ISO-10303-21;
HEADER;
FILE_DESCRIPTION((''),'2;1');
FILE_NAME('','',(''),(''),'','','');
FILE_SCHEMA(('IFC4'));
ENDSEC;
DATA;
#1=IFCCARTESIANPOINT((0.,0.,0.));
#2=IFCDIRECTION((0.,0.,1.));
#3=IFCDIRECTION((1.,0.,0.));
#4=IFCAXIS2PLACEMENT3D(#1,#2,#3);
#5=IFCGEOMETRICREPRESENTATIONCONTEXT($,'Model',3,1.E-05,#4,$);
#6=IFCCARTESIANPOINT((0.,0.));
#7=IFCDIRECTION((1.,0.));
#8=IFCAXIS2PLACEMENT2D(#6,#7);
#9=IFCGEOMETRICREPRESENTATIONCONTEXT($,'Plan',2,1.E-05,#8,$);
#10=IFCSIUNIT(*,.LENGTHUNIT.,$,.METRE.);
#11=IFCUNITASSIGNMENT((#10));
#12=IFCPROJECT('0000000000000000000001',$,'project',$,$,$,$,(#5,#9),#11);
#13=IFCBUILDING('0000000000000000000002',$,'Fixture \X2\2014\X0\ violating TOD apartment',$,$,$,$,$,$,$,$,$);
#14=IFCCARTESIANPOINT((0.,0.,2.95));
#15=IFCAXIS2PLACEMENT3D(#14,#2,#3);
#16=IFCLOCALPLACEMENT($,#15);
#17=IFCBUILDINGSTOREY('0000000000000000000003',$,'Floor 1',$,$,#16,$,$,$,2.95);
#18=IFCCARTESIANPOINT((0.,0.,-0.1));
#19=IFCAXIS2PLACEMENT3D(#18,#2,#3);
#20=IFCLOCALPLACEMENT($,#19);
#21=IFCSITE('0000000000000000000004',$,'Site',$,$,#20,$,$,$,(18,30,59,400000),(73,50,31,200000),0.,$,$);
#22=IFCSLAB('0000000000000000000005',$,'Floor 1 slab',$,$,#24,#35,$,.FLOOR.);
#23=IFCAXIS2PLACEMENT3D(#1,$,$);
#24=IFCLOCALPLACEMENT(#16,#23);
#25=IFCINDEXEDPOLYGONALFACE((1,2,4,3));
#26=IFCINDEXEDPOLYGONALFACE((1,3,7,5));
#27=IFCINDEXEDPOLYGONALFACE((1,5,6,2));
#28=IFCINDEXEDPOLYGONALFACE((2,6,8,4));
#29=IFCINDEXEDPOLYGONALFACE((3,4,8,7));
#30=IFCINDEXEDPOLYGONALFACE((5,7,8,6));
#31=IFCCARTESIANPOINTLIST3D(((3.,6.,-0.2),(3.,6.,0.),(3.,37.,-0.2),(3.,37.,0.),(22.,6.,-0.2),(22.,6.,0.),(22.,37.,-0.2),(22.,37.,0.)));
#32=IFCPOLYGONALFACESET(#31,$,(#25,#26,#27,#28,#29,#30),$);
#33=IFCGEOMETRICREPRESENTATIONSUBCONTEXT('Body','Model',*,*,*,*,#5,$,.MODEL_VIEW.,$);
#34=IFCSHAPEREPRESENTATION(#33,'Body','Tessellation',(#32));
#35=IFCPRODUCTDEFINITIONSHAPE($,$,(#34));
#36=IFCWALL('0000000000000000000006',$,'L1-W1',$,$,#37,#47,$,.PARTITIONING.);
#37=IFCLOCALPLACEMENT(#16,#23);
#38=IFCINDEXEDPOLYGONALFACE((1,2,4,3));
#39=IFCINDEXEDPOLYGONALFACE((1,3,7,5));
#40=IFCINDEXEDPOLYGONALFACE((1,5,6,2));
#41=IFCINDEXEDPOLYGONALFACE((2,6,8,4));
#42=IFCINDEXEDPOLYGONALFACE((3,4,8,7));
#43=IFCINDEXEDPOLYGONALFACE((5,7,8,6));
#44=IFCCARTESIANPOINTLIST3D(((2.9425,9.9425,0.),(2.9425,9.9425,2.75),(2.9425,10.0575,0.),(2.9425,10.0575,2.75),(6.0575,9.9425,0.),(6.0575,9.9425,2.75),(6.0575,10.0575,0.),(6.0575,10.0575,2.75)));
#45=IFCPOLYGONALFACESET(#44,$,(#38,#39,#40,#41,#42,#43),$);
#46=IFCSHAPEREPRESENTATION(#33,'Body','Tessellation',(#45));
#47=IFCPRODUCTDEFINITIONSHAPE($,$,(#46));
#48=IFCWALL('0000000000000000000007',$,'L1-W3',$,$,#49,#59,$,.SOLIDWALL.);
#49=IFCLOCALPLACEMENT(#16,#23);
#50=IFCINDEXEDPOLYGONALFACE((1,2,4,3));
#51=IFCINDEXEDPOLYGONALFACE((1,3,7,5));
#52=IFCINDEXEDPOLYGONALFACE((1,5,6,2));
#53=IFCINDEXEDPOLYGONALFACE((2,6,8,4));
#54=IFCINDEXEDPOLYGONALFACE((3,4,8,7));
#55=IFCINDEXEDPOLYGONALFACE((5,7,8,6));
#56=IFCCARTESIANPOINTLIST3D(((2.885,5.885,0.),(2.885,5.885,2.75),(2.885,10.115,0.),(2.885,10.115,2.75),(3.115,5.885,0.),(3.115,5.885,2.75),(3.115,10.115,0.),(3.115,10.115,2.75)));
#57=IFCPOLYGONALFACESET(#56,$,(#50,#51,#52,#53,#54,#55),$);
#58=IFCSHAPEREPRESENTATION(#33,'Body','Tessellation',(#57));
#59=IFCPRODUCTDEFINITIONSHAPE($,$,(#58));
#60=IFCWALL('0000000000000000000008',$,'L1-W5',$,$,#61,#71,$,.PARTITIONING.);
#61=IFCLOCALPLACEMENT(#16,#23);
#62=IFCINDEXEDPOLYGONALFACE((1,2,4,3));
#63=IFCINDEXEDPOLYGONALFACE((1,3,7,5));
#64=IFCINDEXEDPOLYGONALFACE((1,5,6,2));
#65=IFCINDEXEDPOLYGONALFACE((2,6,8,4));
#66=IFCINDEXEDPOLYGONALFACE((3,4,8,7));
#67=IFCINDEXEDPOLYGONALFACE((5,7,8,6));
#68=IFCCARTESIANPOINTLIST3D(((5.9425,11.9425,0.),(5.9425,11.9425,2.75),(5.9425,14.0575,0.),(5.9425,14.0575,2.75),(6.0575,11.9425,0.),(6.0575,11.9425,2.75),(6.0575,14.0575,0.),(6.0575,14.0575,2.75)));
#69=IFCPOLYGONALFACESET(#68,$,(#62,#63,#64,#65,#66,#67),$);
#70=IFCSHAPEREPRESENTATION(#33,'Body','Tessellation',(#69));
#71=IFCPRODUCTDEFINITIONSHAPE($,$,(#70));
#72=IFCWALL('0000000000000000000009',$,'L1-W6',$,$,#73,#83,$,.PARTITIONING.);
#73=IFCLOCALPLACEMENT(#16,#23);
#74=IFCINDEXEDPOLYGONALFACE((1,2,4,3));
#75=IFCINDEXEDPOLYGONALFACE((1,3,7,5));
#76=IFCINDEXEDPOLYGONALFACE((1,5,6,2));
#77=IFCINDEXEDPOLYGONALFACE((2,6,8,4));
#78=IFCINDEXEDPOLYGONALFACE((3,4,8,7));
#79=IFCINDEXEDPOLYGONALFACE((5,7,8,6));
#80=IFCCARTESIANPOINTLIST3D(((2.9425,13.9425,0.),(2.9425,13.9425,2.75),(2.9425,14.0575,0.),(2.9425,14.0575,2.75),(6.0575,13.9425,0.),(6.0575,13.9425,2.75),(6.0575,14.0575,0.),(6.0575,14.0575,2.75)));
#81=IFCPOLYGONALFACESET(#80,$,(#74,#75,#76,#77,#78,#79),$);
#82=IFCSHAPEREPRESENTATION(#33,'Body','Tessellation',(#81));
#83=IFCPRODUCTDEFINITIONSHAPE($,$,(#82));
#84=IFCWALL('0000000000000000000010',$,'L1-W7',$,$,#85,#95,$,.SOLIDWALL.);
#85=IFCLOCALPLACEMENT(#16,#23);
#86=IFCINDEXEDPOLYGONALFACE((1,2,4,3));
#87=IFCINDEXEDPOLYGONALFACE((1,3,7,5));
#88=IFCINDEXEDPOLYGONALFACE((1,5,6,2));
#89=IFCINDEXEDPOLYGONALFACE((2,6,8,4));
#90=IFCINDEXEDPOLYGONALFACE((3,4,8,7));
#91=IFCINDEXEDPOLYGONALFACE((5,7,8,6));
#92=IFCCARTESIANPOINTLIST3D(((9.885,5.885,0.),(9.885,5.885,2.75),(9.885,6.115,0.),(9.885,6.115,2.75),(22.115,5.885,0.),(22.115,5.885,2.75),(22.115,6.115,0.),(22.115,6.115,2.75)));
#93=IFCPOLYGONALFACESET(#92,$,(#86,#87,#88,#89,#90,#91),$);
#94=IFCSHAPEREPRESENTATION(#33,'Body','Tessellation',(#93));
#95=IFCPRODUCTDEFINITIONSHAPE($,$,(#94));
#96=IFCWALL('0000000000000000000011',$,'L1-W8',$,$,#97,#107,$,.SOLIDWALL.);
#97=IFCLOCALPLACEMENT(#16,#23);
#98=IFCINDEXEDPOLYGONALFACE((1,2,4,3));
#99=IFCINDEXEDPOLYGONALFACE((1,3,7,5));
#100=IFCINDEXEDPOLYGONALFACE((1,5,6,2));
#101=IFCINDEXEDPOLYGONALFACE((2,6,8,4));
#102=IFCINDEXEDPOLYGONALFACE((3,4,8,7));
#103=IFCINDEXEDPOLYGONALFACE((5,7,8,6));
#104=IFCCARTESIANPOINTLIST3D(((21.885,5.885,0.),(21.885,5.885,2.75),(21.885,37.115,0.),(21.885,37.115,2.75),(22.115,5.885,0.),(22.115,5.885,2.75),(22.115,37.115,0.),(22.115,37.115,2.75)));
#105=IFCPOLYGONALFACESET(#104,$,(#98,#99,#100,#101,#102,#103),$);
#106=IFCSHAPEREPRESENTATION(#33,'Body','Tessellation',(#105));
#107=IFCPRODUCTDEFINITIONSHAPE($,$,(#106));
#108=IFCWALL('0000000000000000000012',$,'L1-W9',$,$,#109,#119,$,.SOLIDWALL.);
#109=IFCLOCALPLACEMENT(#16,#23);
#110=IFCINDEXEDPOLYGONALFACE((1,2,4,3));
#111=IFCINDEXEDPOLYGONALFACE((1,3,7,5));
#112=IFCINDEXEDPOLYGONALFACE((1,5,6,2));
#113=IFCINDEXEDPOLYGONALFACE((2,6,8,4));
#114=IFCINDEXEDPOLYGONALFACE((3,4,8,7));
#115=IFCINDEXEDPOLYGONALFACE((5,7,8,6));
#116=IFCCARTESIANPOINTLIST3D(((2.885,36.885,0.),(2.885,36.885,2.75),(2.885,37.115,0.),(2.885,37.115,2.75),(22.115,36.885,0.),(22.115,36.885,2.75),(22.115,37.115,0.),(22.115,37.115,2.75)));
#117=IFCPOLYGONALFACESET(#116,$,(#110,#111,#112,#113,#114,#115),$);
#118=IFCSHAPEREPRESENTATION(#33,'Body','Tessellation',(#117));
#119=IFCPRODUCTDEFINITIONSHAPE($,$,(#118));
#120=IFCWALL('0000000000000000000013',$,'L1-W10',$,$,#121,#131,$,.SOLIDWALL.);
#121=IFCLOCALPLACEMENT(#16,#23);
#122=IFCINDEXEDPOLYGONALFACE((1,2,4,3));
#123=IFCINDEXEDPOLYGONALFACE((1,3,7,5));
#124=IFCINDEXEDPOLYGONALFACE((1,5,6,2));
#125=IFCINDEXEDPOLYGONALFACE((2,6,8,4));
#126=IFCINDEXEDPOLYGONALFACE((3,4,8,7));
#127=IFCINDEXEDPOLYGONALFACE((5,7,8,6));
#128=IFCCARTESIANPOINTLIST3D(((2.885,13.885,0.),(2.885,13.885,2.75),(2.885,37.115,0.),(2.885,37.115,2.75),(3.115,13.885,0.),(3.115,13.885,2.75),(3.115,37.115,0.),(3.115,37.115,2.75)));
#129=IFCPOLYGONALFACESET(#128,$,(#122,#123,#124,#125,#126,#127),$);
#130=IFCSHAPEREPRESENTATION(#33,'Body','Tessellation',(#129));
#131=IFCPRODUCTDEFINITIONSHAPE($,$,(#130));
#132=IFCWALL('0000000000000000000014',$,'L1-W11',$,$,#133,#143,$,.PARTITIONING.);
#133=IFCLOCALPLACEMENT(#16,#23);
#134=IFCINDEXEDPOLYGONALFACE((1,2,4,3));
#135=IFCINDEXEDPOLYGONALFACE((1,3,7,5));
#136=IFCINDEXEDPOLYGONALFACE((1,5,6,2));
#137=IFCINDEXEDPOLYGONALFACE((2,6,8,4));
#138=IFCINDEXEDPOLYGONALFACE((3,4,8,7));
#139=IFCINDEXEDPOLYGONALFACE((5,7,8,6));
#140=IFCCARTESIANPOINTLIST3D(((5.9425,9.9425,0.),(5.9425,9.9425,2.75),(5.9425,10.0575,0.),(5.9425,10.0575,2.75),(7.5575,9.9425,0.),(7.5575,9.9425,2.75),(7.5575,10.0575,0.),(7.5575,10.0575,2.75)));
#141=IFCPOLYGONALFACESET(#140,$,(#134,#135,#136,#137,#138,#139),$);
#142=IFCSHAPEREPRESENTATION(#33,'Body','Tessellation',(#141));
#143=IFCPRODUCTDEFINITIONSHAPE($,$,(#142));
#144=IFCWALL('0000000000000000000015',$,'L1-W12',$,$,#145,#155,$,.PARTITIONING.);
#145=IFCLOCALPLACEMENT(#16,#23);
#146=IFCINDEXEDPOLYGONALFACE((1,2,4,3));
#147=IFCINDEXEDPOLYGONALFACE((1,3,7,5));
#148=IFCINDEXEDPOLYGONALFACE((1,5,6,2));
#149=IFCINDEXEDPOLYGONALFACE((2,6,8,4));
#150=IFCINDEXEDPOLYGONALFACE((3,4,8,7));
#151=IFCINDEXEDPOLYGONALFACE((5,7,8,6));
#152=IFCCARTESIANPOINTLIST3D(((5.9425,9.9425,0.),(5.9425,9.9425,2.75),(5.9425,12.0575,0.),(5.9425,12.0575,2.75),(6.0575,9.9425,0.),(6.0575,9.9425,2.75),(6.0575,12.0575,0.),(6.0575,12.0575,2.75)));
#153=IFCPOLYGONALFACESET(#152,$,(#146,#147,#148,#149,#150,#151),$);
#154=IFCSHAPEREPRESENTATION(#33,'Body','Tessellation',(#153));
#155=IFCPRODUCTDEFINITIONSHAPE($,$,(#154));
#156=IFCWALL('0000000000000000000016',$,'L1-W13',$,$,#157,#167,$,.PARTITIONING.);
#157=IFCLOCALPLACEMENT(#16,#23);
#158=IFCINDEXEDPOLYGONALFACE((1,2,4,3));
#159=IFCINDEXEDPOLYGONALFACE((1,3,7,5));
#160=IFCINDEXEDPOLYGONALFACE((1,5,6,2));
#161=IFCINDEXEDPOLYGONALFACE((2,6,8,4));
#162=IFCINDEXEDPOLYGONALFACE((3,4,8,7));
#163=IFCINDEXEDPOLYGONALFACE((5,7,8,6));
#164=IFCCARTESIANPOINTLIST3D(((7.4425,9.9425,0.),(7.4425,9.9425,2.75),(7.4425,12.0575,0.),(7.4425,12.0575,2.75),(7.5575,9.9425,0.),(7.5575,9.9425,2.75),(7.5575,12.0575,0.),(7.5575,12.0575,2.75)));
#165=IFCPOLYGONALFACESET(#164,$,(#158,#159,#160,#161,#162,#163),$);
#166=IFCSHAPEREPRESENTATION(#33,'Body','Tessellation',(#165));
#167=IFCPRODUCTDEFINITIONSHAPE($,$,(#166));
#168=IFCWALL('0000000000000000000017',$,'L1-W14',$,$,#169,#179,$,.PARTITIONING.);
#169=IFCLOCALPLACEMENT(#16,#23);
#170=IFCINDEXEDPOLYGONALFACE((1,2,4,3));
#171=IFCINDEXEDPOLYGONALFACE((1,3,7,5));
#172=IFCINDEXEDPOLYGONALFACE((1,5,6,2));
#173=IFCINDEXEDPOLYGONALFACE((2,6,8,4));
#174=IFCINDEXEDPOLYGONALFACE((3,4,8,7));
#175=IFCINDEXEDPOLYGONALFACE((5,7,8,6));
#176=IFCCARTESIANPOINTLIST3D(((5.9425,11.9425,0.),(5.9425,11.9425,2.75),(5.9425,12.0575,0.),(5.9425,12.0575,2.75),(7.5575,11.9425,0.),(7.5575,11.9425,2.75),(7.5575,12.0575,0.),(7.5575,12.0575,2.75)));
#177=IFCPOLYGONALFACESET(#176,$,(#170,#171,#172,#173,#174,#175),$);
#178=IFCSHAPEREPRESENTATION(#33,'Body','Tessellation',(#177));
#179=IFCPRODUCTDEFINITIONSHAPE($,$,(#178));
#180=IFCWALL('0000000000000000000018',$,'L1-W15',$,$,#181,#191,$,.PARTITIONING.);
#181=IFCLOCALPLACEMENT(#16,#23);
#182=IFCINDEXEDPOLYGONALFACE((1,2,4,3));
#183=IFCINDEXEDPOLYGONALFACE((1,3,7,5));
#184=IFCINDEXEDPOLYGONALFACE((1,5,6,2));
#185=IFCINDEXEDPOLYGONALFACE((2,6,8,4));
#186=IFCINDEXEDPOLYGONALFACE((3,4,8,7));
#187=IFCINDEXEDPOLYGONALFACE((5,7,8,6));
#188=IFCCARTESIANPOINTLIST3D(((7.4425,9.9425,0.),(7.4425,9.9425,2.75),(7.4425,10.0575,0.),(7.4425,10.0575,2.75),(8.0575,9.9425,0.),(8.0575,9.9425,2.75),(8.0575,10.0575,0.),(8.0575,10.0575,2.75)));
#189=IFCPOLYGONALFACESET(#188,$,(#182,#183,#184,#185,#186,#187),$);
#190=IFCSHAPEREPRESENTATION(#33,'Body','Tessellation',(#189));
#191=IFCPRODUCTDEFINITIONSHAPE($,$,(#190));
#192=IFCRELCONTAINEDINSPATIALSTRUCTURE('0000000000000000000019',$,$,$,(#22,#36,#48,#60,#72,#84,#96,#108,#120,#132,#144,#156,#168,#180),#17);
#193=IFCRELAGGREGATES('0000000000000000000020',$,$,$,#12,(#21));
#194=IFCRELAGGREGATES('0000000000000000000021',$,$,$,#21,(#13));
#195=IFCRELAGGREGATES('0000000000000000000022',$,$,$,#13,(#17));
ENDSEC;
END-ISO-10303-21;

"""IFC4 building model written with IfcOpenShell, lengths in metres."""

from ifc_helpers import new_model, si_unit, frame, origin_with_axes, origin_2d_with_axis, place, context, subcontext, project, spatial, line, indexed_curve, outline, extrude, element, save


model = new_model("IFC4")

# Units and contexts
model_context = context("Model", 3, precision=1e-05, world=origin_with_axes())
plan_context = context("Plan", 2, precision=1e-05, world=origin_2d_with_axis())
body_context = subcontext(model_context, "Body", "Model", "MODEL_VIEW")
ifc_project = project(units=[si_unit("LENGTHUNIT", "METRE")], contexts=[model_context, plan_context])

# Site, building, storey
site_placement = place(None, frame((0.0, 0.0, -0.1), z_axis=(0.0, 0.0, 1.0), x_axis=(1.0, 0.0, 0.0)))
site = spatial("IfcSite", under=ifc_project, at=site_placement, Name="Site", RefLatitude=(18, 30, 59, 400000), RefLongitude=(73, 50, 31, 200000), RefElevation=0.0)
building = spatial("IfcBuilding", under=site, Name="Fixture — violating TOD apartment")
storey_placement = place(None, frame((0.0, 0.0, 2.95), z_axis=(0.0, 0.0, 1.0), x_axis=(1.0, 0.0, 0.0)))
storey = spatial("IfcBuildingStorey", under=building, at=storey_placement, Name="Floor 1", Elevation=2.95)

# Slab
slab_placement = place(storey_placement, frame((0.0, 0.0, -0.2), z_axis=(0.0, 0.0, 1.0), x_axis=(1.0, 0.0, 0.0)))
element("IfcSlab", 1, at=slab_placement, inside=storey, Name="Floor 1 slab", PredefinedType="FLOOR", context=body_context, shape_type="SweptSolid", body=[
    extrude(outline(indexed_curve([(3.0, 6.0), (22.0, 6.0), (22.0, 37.0), (3.0, 37.0)], segments=[line(1, 2, 3, 4, 1)])), origin_with_axes(), (0.0, 0.0, 1.0), 0.2),
])

# Wall
wall_1_placement = place(storey_placement, frame((0.0, 0.0, -2.95), z_axis=(0.0, 0.0, 1.0), x_axis=(1.0, 0.0, 0.0)))
element("IfcWall", 2, at=wall_1_placement, inside=storey, Name="L1-W1", PredefinedType="PARTITIONING", context=body_context, shape_type="SweptSolid", body=[
    extrude(outline(indexed_curve([(6.0575, 9.9425), (2.9425, 9.9425), (2.9425, 10.0575), (6.0575, 10.0575)], segments=[line(1, 2, 3, 4, 1)])), frame((0.0, 0.0, 2.95), z_axis=(0.0, 0.0, 1.0), x_axis=(1.0, 0.0, 0.0)), (0.0, 0.0, 1.0), 2.75),
])

# Wall
wall_2_placement = place(storey_placement, frame((0.0, 0.0, -2.95), z_axis=(0.0, 0.0, 1.0), x_axis=(1.0, 0.0, 0.0)))
element("IfcWall", 3, at=wall_2_placement, inside=storey, Name="L1-W3", PredefinedType="SOLIDWALL", context=body_context, shape_type="SweptSolid", body=[
    extrude(outline(indexed_curve([(3.115, 10.115), (3.115, 5.885), (2.885, 5.885), (2.885, 10.115)], segments=[line(1, 2, 3, 4, 1)])), frame((0.0, 0.0, 2.95), z_axis=(0.0, 0.0, 1.0), x_axis=(1.0, 0.0, 0.0)), (0.0, 0.0, 1.0), 2.75),
])

# Walls
wall_3_placement = place(storey_placement, frame((0.0, 0.0, -2.95), z_axis=(0.0, 0.0, 1.0), x_axis=(1.0, 0.0, 0.0)))
element("IfcWall", 4, at=wall_3_placement, inside=storey, Name="L1-W5", PredefinedType="PARTITIONING", context=body_context, shape_type="SweptSolid", body=[
    extrude(outline(indexed_curve([(5.9425, 11.9425), (5.9425, 14.0575), (6.0575, 14.0575), (6.0575, 11.9425)], segments=[line(1, 2, 3, 4, 1)])), frame((0.0, 0.0, 2.95), z_axis=(0.0, 0.0, 1.0), x_axis=(1.0, 0.0, 0.0)), (0.0, 0.0, 1.0), 2.75),
])
wall_4_placement = place(storey_placement, frame((0.0, 0.0, -2.95), z_axis=(0.0, 0.0, 1.0), x_axis=(1.0, 0.0, 0.0)))
element("IfcWall", 5, at=wall_4_placement, inside=storey, Name="L1-W6", PredefinedType="PARTITIONING", context=body_context, shape_type="SweptSolid", body=[
    extrude(outline(indexed_curve([(6.0575, 13.9425), (2.9425, 13.9425), (2.9425, 14.0575), (6.0575, 14.0575)], segments=[line(1, 2, 3, 4, 1)])), frame((0.0, 0.0, 2.95), z_axis=(0.0, 0.0, 1.0), x_axis=(1.0, 0.0, 0.0)), (0.0, 0.0, 1.0), 2.75),
])
wall_5_placement = place(storey_placement, frame((0.0, 0.0, -2.95), z_axis=(0.0, 0.0, 1.0), x_axis=(1.0, 0.0, 0.0)))
element("IfcWall", 6, at=wall_5_placement, inside=storey, Name="L1-W7", PredefinedType="SOLIDWALL", context=body_context, shape_type="SweptSolid", body=[
    extrude(outline(indexed_curve([(9.885, 6.115), (22.115, 6.115), (22.115, 5.885), (9.885, 5.885)], segments=[line(1, 2, 3, 4, 1)])), frame((0.0, 0.0, 2.95), z_axis=(0.0, 0.0, 1.0), x_axis=(1.0, 0.0, 0.0)), (0.0, 0.0, 1.0), 2.75),
])
wall_6_placement = place(storey_placement, frame((0.0, 0.0, -2.95), z_axis=(0.0, 0.0, 1.0), x_axis=(1.0, 0.0, 0.0)))
element("IfcWall", 7, at=wall_6_placement, inside=storey, Name="L1-W8", PredefinedType="SOLIDWALL", context=body_context, shape_type="SweptSolid", body=[
    extrude(outline(indexed_curve([(21.885, 5.885), (21.885, 37.115), (22.115, 37.115), (22.115, 5.885)], segments=[line(1, 2, 3, 4, 1)])), frame((0.0, 0.0, 2.95), z_axis=(0.0, 0.0, 1.0), x_axis=(1.0, 0.0, 0.0)), (0.0, 0.0, 1.0), 2.75),
])
wall_7_placement = place(storey_placement, frame((0.0, 0.0, -2.95), z_axis=(0.0, 0.0, 1.0), x_axis=(1.0, 0.0, 0.0)))
element("IfcWall", 8, at=wall_7_placement, inside=storey, Name="L1-W9", PredefinedType="SOLIDWALL", context=body_context, shape_type="SweptSolid", body=[
    extrude(outline(indexed_curve([(22.115, 36.885), (2.885, 36.885), (2.885, 37.115), (22.115, 37.115)], segments=[line(1, 2, 3, 4, 1)])), frame((0.0, 0.0, 2.95), z_axis=(0.0, 0.0, 1.0), x_axis=(1.0, 0.0, 0.0)), (0.0, 0.0, 1.0), 2.75),
])
wall_8_placement = place(storey_placement, frame((0.0, 0.0, -2.95), z_axis=(0.0, 0.0, 1.0), x_axis=(1.0, 0.0, 0.0)))
element("IfcWall", 9, at=wall_8_placement, inside=storey, Name="L1-W10", PredefinedType="SOLIDWALL", context=body_context, shape_type="SweptSolid", body=[
    extrude(outline(indexed_curve([(3.115, 37.115), (3.115, 13.885), (2.885, 13.885), (2.885, 37.115)], segments=[line(1, 2, 3, 4, 1)])), frame((0.0, 0.0, 2.95), z_axis=(0.0, 0.0, 1.0), x_axis=(1.0, 0.0, 0.0)), (0.0, 0.0, 1.0), 2.75),
])
wall_9_placement = place(storey_placement, frame((0.0, 0.0, -2.95), z_axis=(0.0, 0.0, 1.0), x_axis=(1.0, 0.0, 0.0)))
element("IfcWall", 10, at=wall_9_placement, inside=storey, Name="L1-W11", PredefinedType="PARTITIONING", context=body_context, shape_type="SweptSolid", body=[
    extrude(outline(indexed_curve([(7.5575, 9.9425), (5.9425, 9.9425), (5.9425, 10.0575), (7.5575, 10.0575)], segments=[line(1, 2, 3, 4, 1)])), frame((0.0, 0.0, 2.95), z_axis=(0.0, 0.0, 1.0), x_axis=(1.0, 0.0, 0.0)), (0.0, 0.0, 1.0), 2.75),
])
wall_10_placement = place(storey_placement, frame((0.0, 0.0, -2.95), z_axis=(0.0, 0.0, 1.0), x_axis=(1.0, 0.0, 0.0)))
element("IfcWall", 11, at=wall_10_placement, inside=storey, Name="L1-W12", PredefinedType="PARTITIONING", context=body_context, shape_type="SweptSolid", body=[
    extrude(outline(indexed_curve([(5.9425, 9.9425), (5.9425, 12.0575), (6.0575, 12.0575), (6.0575, 9.9425)], segments=[line(1, 2, 3, 4, 1)])), frame((0.0, 0.0, 2.95), z_axis=(0.0, 0.0, 1.0), x_axis=(1.0, 0.0, 0.0)), (0.0, 0.0, 1.0), 2.75),
])
wall_11_placement = place(storey_placement, frame((0.0, 0.0, -2.95), z_axis=(0.0, 0.0, 1.0), x_axis=(1.0, 0.0, 0.0)))
element("IfcWall", 12, at=wall_11_placement, inside=storey, Name="L1-W13", PredefinedType="PARTITIONING", context=body_context, shape_type="SweptSolid", body=[
    extrude(outline(indexed_curve([(7.4425, 9.9425), (7.4425, 12.0575), (7.5575, 12.0575), (7.5575, 9.9425)], segments=[line(1, 2, 3, 4, 1)])), frame((0.0, 0.0, 2.95), z_axis=(0.0, 0.0, 1.0), x_axis=(1.0, 0.0, 0.0)), (0.0, 0.0, 1.0), 2.75),
])
wall_12_placement = place(storey_placement, frame((0.0, 0.0, -2.95), z_axis=(0.0, 0.0, 1.0), x_axis=(1.0, 0.0, 0.0)))
element("IfcWall", 13, at=wall_12_placement, inside=storey, Name="L1-W14", PredefinedType="PARTITIONING", context=body_context, shape_type="SweptSolid", body=[
    extrude(outline(indexed_curve([(7.5575, 11.9425), (5.9425, 11.9425), (5.9425, 12.0575), (7.5575, 12.0575)], segments=[line(1, 2, 3, 4, 1)])), frame((0.0, 0.0, 2.95), z_axis=(0.0, 0.0, 1.0), x_axis=(1.0, 0.0, 0.0)), (0.0, 0.0, 1.0), 2.75),
])
wall_13_placement = place(storey_placement, frame((0.0, 0.0, -2.95), z_axis=(0.0, 0.0, 1.0), x_axis=(1.0, 0.0, 0.0)))
element("IfcWall", 14, at=wall_13_placement, inside=storey, Name="L1-W15", PredefinedType="PARTITIONING", context=body_context, shape_type="SweptSolid", body=[
    extrude(outline(indexed_curve([(8.0575, 9.9425), (7.4425, 9.9425), (7.4425, 10.0575), (8.0575, 10.0575)], segments=[line(1, 2, 3, 4, 1)])), frame((0.0, 0.0, 2.95), z_axis=(0.0, 0.0, 1.0), x_axis=(1.0, 0.0, 0.0)), (0.0, 0.0, 1.0), 2.75),
])

save(model, "model.ifc")
